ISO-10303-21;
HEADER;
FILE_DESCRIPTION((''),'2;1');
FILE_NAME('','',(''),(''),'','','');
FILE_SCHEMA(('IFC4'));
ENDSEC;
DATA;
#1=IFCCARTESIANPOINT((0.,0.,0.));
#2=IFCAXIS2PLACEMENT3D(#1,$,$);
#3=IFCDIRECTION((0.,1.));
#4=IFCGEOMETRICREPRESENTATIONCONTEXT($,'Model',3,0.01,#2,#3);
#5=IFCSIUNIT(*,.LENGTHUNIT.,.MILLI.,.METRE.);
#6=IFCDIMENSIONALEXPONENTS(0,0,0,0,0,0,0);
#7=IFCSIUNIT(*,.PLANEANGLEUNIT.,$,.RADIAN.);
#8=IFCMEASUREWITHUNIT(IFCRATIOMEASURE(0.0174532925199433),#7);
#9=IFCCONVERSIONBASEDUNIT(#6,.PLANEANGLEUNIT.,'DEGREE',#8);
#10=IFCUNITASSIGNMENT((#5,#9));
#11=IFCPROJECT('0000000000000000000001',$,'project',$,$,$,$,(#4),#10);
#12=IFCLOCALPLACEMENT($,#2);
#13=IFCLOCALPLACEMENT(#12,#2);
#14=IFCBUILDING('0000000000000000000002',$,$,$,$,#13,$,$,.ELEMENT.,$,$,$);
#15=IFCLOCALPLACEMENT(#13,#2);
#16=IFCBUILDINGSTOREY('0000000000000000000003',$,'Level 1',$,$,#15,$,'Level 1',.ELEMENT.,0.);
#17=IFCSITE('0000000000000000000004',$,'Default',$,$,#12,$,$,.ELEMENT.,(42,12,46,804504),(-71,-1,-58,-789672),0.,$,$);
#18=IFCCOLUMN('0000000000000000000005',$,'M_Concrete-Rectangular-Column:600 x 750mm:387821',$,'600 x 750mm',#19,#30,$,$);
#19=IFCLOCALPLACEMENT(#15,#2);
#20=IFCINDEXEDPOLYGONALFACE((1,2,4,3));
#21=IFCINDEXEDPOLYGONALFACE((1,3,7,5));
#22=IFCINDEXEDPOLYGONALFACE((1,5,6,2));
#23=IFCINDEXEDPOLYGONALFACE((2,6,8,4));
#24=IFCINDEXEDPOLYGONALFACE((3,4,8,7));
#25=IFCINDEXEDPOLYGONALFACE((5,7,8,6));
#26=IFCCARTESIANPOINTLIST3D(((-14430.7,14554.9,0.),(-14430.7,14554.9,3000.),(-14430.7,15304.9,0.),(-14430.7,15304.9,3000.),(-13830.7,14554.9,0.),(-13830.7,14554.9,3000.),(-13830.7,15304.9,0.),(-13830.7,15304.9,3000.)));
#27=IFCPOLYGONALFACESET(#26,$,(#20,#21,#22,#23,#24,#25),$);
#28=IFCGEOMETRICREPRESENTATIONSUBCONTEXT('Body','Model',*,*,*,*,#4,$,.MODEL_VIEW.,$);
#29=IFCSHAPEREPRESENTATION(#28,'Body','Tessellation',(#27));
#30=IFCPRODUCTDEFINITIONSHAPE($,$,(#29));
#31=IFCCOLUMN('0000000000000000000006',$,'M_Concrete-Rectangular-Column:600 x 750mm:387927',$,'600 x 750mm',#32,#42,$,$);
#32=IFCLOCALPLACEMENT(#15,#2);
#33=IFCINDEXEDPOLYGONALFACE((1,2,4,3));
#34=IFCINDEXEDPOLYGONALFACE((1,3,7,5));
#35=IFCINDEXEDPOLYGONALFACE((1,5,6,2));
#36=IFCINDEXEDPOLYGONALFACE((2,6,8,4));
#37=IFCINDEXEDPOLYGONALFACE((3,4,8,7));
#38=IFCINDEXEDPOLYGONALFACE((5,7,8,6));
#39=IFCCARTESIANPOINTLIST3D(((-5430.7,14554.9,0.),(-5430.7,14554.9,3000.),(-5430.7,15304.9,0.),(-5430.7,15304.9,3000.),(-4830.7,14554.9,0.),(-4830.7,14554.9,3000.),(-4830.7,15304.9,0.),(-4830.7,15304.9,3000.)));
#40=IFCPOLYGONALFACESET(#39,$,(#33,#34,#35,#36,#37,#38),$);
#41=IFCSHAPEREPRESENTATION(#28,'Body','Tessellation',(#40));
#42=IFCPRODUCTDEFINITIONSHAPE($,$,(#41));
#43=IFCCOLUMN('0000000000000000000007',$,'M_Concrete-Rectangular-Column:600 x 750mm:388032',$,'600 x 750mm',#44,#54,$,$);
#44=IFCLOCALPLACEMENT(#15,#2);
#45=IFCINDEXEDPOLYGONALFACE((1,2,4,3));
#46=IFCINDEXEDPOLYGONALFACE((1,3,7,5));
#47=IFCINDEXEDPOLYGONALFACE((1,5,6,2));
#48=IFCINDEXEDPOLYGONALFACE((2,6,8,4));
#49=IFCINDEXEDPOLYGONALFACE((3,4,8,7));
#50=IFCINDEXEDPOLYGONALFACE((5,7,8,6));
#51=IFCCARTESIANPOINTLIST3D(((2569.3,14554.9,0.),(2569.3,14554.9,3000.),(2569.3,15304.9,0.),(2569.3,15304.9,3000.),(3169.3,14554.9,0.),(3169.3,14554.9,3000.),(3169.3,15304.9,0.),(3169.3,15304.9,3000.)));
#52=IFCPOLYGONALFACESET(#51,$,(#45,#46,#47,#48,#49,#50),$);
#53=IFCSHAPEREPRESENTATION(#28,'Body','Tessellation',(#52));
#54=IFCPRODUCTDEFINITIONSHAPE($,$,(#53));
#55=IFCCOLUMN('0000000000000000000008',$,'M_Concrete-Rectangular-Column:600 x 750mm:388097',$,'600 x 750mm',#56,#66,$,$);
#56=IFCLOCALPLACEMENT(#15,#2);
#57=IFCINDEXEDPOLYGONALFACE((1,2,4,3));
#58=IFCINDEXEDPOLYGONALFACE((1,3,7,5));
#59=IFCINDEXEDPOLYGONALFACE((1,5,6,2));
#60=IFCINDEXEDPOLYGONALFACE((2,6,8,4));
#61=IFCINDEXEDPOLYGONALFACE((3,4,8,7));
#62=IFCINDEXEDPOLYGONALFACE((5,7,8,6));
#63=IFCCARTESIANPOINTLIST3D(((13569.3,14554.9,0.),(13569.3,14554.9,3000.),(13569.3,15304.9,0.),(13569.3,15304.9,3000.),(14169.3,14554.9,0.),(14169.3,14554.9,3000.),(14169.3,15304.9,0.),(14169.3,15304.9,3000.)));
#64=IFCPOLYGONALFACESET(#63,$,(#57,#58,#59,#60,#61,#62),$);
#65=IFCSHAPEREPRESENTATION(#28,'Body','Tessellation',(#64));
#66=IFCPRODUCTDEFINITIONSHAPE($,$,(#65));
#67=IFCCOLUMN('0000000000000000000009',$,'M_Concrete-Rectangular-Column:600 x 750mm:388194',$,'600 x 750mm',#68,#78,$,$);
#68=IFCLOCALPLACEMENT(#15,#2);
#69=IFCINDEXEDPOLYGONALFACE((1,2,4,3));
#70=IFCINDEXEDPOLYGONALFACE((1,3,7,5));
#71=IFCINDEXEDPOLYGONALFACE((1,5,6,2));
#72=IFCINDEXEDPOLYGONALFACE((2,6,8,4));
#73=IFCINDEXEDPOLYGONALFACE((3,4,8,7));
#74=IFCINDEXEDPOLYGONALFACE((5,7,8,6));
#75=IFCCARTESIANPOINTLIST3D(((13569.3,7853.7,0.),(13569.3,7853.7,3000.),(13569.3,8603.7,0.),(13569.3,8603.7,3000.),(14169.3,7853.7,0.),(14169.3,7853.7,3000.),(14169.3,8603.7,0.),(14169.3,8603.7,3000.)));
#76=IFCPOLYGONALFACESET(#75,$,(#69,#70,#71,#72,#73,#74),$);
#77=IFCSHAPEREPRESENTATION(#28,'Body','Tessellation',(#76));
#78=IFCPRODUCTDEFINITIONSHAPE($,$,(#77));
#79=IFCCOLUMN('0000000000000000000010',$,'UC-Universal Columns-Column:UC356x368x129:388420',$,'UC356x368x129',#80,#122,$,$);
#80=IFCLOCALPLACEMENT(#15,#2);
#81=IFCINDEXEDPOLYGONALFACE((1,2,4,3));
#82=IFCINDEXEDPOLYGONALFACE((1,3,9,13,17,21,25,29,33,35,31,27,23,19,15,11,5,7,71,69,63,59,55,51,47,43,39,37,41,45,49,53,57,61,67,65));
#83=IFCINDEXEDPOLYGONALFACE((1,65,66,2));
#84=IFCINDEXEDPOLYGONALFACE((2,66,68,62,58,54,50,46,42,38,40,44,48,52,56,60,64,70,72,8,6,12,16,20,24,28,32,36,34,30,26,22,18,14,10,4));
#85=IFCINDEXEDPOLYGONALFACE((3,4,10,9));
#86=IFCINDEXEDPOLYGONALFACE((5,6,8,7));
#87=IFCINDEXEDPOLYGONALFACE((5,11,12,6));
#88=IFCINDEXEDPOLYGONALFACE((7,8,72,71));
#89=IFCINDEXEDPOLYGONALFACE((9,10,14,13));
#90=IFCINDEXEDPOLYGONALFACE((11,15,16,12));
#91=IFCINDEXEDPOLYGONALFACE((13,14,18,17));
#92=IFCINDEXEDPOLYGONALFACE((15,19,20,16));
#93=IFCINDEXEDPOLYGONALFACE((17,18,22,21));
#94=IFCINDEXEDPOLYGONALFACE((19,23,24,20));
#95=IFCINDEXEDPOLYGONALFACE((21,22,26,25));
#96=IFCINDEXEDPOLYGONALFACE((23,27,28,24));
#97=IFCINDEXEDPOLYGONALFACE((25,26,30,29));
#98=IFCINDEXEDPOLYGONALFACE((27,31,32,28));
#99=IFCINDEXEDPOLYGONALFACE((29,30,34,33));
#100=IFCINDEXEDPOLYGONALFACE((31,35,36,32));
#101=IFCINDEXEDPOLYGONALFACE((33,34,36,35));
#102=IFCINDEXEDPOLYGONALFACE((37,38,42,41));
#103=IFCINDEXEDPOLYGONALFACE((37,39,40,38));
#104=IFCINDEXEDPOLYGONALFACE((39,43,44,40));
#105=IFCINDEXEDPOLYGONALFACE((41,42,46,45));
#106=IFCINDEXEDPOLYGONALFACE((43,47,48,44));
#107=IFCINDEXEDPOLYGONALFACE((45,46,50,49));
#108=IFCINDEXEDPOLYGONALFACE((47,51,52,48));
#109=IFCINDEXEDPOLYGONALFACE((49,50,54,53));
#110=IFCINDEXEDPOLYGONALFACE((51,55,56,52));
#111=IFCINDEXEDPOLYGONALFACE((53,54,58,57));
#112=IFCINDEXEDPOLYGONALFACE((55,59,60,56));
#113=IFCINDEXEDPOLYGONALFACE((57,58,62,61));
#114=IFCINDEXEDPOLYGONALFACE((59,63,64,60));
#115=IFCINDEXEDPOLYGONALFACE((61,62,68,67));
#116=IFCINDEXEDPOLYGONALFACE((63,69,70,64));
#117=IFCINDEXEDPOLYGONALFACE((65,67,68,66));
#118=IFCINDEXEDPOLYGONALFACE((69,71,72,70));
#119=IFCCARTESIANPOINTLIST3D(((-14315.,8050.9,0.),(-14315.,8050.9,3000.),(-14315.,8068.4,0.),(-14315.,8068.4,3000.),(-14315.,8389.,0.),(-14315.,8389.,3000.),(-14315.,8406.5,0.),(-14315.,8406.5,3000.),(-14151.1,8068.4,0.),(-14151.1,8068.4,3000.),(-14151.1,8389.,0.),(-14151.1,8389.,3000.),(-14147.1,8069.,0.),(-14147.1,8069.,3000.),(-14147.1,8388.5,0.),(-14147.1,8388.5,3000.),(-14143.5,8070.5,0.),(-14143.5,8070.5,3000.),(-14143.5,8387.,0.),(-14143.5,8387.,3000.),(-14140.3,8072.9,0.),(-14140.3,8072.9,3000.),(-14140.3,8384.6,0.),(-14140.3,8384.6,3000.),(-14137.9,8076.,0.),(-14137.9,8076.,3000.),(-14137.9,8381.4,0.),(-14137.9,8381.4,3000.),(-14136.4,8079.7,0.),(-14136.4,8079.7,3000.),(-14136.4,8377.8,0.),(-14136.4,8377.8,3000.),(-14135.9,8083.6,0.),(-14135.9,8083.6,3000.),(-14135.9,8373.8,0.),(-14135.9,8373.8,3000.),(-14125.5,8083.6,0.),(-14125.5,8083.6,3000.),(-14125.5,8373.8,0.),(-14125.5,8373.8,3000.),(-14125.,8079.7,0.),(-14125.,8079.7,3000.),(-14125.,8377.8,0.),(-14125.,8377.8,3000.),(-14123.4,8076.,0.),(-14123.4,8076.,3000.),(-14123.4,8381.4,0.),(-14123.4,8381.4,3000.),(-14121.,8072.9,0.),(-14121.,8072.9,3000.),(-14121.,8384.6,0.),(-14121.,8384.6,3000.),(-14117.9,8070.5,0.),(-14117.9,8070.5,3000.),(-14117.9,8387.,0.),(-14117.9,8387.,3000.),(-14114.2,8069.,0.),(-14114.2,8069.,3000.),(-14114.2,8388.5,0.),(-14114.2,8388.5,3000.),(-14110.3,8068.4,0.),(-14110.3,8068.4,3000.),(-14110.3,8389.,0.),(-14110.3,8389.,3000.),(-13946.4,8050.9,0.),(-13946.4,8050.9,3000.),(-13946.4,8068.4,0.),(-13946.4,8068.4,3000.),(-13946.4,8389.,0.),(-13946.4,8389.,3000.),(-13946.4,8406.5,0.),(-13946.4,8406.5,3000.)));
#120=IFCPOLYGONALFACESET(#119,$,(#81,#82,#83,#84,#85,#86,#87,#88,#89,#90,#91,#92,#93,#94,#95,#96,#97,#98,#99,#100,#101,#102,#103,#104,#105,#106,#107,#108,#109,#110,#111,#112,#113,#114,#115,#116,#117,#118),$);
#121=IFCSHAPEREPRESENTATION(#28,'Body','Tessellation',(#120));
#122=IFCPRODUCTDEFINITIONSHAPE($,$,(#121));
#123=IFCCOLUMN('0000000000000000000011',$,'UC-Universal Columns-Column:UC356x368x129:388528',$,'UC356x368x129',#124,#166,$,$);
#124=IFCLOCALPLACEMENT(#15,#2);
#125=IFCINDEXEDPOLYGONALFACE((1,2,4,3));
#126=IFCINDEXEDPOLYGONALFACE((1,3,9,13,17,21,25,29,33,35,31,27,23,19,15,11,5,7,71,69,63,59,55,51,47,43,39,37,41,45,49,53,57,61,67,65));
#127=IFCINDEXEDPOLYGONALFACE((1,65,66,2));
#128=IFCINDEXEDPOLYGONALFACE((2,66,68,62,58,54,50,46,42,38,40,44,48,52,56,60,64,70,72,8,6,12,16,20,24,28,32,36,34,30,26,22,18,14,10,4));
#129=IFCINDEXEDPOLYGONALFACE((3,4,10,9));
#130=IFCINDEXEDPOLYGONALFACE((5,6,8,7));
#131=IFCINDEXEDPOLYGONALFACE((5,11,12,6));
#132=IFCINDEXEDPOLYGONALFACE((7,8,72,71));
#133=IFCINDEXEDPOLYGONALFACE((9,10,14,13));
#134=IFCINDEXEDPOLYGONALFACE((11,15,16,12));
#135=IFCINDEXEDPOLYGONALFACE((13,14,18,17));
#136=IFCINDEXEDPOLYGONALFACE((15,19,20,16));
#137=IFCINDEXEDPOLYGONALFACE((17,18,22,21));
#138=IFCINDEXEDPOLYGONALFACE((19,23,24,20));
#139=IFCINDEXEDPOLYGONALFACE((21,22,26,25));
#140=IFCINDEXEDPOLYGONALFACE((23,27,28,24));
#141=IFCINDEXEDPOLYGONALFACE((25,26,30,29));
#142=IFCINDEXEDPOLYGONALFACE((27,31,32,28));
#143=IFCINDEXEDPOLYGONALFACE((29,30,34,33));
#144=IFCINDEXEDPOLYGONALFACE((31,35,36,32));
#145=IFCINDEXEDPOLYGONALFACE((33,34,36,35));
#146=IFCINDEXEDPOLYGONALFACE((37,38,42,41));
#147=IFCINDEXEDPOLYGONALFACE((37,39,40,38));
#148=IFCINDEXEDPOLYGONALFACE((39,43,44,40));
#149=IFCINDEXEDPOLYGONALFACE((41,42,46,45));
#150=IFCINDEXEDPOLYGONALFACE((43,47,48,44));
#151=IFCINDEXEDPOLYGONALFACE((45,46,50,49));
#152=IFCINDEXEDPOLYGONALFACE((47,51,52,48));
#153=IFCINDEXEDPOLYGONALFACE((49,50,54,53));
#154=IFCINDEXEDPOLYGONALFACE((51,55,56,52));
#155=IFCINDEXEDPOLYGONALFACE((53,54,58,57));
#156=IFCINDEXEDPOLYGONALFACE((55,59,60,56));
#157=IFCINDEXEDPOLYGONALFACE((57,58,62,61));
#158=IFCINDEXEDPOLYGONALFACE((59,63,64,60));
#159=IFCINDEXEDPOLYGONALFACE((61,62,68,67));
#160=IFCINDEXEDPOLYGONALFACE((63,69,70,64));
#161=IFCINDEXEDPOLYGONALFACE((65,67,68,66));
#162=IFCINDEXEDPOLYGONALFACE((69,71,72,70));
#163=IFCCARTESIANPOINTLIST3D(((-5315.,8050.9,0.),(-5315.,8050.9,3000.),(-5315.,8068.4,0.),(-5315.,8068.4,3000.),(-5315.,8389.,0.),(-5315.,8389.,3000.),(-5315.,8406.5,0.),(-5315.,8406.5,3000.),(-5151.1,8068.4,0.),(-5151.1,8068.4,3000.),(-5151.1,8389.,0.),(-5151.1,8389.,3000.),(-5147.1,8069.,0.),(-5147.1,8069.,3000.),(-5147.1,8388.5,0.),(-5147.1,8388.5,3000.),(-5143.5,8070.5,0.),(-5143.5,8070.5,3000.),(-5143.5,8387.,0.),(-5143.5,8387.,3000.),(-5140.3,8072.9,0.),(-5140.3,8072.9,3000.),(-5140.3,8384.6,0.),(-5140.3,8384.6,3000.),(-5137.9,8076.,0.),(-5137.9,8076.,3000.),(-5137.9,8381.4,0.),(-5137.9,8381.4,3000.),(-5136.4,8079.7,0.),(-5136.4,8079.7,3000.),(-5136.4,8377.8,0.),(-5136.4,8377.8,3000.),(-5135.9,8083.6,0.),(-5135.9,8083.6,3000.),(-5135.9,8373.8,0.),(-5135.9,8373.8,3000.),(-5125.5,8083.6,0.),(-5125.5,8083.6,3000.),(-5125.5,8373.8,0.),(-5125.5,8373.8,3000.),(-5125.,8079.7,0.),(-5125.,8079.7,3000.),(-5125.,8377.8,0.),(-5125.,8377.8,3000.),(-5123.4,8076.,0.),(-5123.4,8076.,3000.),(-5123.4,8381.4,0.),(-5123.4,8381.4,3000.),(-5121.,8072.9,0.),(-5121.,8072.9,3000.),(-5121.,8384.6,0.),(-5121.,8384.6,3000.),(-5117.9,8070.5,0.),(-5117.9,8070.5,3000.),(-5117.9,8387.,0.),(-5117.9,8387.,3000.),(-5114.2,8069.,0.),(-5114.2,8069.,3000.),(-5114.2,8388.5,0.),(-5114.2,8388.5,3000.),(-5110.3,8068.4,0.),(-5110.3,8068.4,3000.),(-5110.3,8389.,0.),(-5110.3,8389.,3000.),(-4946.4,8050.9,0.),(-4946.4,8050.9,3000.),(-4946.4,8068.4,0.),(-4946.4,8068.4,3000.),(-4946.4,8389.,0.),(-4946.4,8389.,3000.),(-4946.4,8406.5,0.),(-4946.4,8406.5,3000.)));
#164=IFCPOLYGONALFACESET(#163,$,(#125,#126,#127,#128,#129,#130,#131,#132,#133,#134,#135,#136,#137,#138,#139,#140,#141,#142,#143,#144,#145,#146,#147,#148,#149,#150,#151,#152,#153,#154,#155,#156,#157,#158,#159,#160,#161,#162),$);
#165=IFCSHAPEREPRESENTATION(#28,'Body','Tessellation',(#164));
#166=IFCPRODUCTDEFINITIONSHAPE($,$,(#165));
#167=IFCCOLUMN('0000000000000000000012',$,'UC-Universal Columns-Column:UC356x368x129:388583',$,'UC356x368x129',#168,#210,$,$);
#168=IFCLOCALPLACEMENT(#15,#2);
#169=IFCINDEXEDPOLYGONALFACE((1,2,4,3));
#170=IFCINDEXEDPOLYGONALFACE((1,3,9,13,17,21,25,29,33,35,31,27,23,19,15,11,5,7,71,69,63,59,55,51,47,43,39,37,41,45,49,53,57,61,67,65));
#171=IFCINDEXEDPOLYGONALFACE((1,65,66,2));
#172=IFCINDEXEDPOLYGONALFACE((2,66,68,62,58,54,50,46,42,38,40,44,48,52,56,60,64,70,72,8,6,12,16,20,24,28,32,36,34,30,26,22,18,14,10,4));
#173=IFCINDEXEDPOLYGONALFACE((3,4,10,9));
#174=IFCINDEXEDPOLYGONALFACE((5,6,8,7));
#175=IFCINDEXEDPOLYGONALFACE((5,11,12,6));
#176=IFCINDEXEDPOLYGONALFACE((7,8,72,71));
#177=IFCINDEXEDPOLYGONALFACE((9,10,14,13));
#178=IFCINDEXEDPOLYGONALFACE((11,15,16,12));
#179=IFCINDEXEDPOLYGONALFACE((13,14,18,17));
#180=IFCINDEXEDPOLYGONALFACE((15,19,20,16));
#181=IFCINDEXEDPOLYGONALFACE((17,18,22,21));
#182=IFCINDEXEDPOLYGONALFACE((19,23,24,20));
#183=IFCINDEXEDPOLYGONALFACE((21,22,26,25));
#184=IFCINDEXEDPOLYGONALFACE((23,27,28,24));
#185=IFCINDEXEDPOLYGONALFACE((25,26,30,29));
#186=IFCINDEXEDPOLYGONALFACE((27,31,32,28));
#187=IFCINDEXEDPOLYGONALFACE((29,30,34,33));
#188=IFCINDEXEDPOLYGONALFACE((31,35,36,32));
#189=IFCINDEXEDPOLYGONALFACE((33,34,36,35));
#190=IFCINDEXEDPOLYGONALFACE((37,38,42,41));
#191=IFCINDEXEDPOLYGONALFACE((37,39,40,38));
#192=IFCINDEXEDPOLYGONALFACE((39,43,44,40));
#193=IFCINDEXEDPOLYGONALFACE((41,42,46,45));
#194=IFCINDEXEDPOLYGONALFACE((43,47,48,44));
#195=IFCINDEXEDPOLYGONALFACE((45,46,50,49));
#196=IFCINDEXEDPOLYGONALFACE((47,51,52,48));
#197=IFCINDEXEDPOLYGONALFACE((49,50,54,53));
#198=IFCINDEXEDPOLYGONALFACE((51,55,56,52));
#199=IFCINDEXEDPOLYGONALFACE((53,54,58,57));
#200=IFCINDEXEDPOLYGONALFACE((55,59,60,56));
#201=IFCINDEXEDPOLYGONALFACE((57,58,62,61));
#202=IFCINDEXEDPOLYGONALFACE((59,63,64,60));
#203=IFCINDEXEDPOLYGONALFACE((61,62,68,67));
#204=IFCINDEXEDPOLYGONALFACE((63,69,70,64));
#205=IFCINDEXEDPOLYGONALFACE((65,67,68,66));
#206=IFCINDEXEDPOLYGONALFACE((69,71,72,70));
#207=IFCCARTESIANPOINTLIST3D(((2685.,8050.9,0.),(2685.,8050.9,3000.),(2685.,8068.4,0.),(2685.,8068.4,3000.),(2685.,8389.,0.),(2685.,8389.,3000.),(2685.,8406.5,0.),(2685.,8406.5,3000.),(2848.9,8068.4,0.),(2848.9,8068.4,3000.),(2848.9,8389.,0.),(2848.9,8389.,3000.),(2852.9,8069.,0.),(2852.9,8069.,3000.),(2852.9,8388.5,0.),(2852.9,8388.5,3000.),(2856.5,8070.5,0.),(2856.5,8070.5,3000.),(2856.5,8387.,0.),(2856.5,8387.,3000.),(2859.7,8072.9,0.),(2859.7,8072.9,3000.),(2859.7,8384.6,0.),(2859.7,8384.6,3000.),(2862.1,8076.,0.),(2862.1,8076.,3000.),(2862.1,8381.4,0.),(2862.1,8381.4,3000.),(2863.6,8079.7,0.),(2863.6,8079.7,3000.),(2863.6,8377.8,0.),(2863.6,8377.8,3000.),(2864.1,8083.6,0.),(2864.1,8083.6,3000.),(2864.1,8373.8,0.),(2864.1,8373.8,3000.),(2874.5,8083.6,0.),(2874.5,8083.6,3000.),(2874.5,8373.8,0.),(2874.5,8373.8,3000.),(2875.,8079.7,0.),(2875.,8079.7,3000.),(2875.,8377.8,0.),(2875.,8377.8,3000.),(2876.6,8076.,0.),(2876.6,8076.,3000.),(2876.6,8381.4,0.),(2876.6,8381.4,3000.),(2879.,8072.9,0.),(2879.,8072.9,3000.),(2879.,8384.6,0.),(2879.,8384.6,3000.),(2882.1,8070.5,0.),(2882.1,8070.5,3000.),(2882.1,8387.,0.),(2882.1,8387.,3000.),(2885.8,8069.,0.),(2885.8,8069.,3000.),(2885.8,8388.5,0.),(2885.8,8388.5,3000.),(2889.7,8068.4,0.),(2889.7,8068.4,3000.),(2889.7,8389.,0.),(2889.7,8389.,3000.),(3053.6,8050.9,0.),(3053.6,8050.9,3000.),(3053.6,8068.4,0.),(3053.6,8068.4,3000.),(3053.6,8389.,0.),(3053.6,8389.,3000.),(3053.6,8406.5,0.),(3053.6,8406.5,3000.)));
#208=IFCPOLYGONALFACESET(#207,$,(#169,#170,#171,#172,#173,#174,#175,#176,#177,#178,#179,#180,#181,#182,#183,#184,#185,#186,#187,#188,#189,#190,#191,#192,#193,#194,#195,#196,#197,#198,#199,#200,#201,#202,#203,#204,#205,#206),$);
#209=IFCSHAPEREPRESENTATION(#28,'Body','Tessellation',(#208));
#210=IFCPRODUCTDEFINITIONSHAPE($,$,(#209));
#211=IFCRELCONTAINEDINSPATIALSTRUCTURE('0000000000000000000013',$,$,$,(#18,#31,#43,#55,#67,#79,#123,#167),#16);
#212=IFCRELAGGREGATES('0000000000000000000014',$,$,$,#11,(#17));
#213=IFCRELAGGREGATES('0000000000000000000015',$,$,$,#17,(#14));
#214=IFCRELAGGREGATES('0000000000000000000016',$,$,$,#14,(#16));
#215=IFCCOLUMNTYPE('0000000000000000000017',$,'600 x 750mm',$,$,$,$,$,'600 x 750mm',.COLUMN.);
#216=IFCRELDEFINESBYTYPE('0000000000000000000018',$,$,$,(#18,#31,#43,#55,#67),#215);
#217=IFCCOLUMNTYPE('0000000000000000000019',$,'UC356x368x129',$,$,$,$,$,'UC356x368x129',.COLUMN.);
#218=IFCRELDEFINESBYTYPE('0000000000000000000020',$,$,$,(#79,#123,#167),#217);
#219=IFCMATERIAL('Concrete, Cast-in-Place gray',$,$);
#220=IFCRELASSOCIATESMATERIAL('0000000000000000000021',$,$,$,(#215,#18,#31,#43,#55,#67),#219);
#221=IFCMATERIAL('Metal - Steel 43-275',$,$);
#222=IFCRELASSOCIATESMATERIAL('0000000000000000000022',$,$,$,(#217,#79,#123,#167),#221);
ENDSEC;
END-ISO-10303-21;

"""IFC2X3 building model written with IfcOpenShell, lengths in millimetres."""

from ifc_helpers import new_model, entity, si_unit, converted_unit, direction, frame, frame_2d, origin, origin_2d_with_axis, place, context, subcontext, project, spatial, rectangle, i_section, extrude, source, transform, mapped, material, type_object, type_shapes, element, save


model = new_model("IFC2X3")

# Units and contexts
model_context = context("Model", 3, precision=0.01, world=origin(), true_north=direction((0.0, 1.0)))
body_context = subcontext(model_context, "Body", "Model", "MODEL_VIEW")
ifc_project = project(units=[si_unit("LENGTHUNIT", "METRE", prefix="MILLI"), converted_unit("PLANEANGLEUNIT", "DEGREE", entity("IfcRatioMeasure", 0.0174532925199433), si_unit("PLANEANGLEUNIT", "RADIAN"), dimensions=[0, 0, 0, 0, 0, 0, 0])], contexts=[model_context])

# Site, building, storey
site_placement = place(None, origin())
site = spatial("IfcSite", under=ifc_project, at=site_placement, Name="Default", CompositionType="ELEMENT", RefLatitude=(42, 12, 46, 804504), RefLongitude=(-71, -1, -58, -789672), RefElevation=0.0)
building_placement = place(site_placement, origin())
building = spatial("IfcBuilding", under=site, at=building_placement, CompositionType="ELEMENT")
storey_placement = place(building_placement, origin())
storey = spatial("IfcBuildingStorey", under=building, at=storey_placement, Name="Level 1", LongName="Level 1", CompositionType="ELEMENT", Elevation=0.0)

# Columns
ifc_material_1 = material(Name="Concrete, Cast-in-Place gray")
column_type_1 = type_object("IfcColumnType", Name="600 x 750mm", ElementType="600 x 750mm", PredefinedType="COLUMN", material=ifc_material_1)
shared_shape_1 = source(origin(), body_context, "Body", "SweptSolid", [
    extrude(rectangle(XDim=750.0, YDim=600.0, at=origin_2d_with_axis()), frame((0.0, 0.0, 0.0), z_axis=(0.0, 0.0, 1.0), x_axis=(0.0, -1.0, 0.0)), (0.0, 0.0, 1.0), 3000.0),
])
type_shapes(column_type_1, [shared_shape_1])
for number, where, name in (
    (1, (-14130.7, 14929.9, 0.0), "M_Concrete-Rectangular-Column:600 x 750mm:387821"),
    (2, (-5130.7, 14929.9, 0.0), "M_Concrete-Rectangular-Column:600 x 750mm:387927"),
    (3, (2869.3, 14929.9, 0.0), "M_Concrete-Rectangular-Column:600 x 750mm:388032"),
    (4, (13869.3, 14929.9, 0.0), "M_Concrete-Rectangular-Column:600 x 750mm:388097"),
    (5, (13869.3, 8228.7, 0.0), "M_Concrete-Rectangular-Column:600 x 750mm:388194"),
):
    element("IfcColumn", number, at=place(storey_placement, frame(where)), inside=storey, type_object=column_type_1, material=ifc_material_1, Name=name, ObjectType="600 x 750mm", context=body_context, shape_type="MappedRepresentation", body=[
        mapped(shared_shape_1, transform((0.0, 0.0, 0.0), scale=1.0)),
    ])
ifc_material_2 = material(Name="Metal - Steel 43-275")
column_type_2 = type_object("IfcColumnType", Name="UC356x368x129", ElementType="UC356x368x129", PredefinedType="COLUMN", material=ifc_material_2)
shared_shape_2 = source(origin(), body_context, "Body", "SweptSolid", [
    extrude(i_section(OverallWidth=368.6, OverallDepth=355.6, WebThickness=10.4, FlangeThickness=17.5, FilletRadius=15.2, at=frame_2d((0.0, 0.0), x_axis=(0.0, 1.0))), frame((0.0, 0.0, 0.0), z_axis=(0.0, 0.0, 1.0), x_axis=(0.0, -1.0, 0.0)), (0.0, 0.0, 1.0), 3000.0),
])
type_shapes(column_type_2, [shared_shape_2])
for number, where, name in (
    (6, (-14130.7, 8228.7, 0.0), "UC-Universal Columns-Column:UC356x368x129:388420"),
    (7, (-5130.7, 8228.7, 0.0), "UC-Universal Columns-Column:UC356x368x129:388528"),
    (8, (2869.3, 8228.7, 0.0), "UC-Universal Columns-Column:UC356x368x129:388583"),
):
    element("IfcColumn", number, at=place(storey_placement, frame(where)), inside=storey, type_object=column_type_2, material=ifc_material_2, Name=name, ObjectType="UC356x368x129", context=body_context, shape_type="MappedRepresentation", body=[
        mapped(shared_shape_2, transform((0.0, 0.0, 0.0), scale=1.0)),
    ])

save(model, "model.ifc")
